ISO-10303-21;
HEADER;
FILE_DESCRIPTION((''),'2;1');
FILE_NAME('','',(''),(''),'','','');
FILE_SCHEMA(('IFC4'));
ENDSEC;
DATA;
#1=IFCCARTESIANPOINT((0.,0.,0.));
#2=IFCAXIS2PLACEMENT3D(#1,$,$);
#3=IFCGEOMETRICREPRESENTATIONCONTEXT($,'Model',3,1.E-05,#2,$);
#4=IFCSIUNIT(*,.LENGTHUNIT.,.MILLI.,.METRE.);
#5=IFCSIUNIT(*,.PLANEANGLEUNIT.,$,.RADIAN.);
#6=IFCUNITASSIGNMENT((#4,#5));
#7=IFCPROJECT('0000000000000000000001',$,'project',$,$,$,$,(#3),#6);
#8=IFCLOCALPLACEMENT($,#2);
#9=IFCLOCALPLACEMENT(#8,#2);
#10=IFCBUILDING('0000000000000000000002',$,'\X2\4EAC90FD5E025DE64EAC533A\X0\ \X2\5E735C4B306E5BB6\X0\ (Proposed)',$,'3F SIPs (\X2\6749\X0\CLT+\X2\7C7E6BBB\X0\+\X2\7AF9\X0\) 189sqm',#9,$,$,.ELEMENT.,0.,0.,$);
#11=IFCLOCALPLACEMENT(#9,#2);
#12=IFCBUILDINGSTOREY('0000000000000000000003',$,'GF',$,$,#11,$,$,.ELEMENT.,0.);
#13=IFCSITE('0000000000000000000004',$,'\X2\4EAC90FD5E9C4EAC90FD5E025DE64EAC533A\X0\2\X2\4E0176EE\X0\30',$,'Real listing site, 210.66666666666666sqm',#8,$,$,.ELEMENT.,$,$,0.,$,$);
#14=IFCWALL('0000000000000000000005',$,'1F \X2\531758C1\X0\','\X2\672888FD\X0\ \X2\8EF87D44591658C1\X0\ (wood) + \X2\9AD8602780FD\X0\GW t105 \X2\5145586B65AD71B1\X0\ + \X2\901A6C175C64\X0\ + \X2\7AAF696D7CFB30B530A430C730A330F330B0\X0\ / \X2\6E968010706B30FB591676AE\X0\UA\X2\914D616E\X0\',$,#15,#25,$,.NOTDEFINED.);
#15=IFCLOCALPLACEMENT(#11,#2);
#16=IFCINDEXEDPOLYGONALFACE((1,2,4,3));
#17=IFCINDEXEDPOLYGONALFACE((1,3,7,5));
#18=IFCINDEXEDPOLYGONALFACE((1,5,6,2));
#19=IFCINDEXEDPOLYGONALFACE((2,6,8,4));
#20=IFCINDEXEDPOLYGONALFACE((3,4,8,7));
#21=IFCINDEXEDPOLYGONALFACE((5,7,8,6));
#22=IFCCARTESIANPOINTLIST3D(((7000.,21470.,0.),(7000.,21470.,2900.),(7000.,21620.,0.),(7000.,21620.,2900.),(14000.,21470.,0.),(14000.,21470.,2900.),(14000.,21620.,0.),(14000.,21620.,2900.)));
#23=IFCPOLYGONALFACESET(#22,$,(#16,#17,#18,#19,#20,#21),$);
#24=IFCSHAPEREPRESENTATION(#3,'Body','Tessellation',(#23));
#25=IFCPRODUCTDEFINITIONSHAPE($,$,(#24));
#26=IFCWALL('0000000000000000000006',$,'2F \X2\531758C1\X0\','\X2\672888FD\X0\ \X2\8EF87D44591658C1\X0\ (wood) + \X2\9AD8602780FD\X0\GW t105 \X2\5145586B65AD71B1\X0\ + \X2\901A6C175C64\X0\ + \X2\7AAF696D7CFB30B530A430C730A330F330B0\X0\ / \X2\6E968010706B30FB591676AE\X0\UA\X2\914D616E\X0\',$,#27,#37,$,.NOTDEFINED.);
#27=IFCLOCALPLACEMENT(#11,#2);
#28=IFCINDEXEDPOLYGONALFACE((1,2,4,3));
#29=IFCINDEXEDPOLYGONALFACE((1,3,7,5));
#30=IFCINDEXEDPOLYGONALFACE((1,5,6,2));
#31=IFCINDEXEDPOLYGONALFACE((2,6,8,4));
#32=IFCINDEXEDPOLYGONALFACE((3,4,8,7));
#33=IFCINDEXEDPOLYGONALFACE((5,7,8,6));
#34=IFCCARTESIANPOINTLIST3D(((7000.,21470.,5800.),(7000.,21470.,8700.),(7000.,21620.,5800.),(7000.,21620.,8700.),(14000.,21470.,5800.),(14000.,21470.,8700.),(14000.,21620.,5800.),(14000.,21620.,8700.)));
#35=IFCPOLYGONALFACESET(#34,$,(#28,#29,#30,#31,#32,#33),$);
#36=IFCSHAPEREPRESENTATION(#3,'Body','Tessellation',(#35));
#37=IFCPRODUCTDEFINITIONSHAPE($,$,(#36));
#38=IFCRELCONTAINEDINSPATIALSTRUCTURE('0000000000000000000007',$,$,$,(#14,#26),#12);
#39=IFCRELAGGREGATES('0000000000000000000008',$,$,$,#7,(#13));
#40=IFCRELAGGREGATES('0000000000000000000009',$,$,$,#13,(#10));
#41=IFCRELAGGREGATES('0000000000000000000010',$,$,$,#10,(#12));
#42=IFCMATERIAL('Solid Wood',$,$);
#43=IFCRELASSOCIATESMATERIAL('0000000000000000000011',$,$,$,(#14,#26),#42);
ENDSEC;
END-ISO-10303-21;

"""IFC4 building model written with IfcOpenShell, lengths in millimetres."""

from ifc_helpers import new_model, si_unit, frame, frame_2d, origin, place, context, project, spatial, rectangle, extrude, material, element, save


model = new_model("IFC4")

# Units and contexts
model_context = context("Model", 3, precision=1e-05, world=origin())
ifc_project = project(units=[si_unit("LENGTHUNIT", "METRE", prefix="MILLI"), si_unit("PLANEANGLEUNIT", "RADIAN")], contexts=[model_context])

# Site, building, storey
site_placement = place(None, origin())
site = spatial("IfcSite", under=ifc_project, at=site_placement, Name="京都府京都市左京区2丁目30", ObjectType="Real listing site, 210.66666666666666sqm", CompositionType="ELEMENT", RefElevation=0.0)
building_placement = place(site_placement, origin())
building = spatial("IfcBuilding", under=site, at=building_placement, Name="京都市左京区 平屋の家 (Proposed)", ObjectType="3F SIPs (杉CLT+籾殻+竹) 189sqm", CompositionType="ELEMENT", ElevationOfRefHeight=0.0, ElevationOfTerrain=0.0)
storey_placement = place(building_placement, origin())
storey = spatial("IfcBuildingStorey", under=building, at=storey_placement, Name="GF", CompositionType="ELEMENT", Elevation=0.0)

# Shared definitions
ifc_material_1 = material(Name="Solid Wood")

# Wall
wall_1_placement = place(storey_placement, frame((3500.0, 10735.0, 0.0)))
element("IfcWall", 1, at=wall_1_placement, inside=storey, material=ifc_material_1, Name="1F 北壁", Description="木製 軸組外壁 (wood) + 高性能GW t105 充填断熱 + 通気層 + 窯業系サイディング / 準耐火・外皮UA配慮", PredefinedType="NOTDEFINED", context=model_context, shape_type="SweptSolid", body=[
    extrude(rectangle(XDim=7000.0, YDim=150.0, at=frame_2d((3500.0, 75.0))), frame((3500.0, 10735.0, 0.0)), (0.0, 0.0, 1.0), 2900.0),
])

# Wall
wall_2_placement = place(storey_placement, frame((3500.0, 10735.0, 2900.0)))
element("IfcWall", 2, at=wall_2_placement, inside=storey, material=ifc_material_1, Name="2F 北壁", Description="木製 軸組外壁 (wood) + 高性能GW t105 充填断熱 + 通気層 + 窯業系サイディング / 準耐火・外皮UA配慮", PredefinedType="NOTDEFINED", context=model_context, shape_type="SweptSolid", body=[
    extrude(rectangle(XDim=7000.0, YDim=150.0, at=frame_2d((3500.0, 75.0))), frame((3500.0, 10735.0, 2900.0)), (0.0, 0.0, 1.0), 2900.0),
])

save(model, "model.ifc")
